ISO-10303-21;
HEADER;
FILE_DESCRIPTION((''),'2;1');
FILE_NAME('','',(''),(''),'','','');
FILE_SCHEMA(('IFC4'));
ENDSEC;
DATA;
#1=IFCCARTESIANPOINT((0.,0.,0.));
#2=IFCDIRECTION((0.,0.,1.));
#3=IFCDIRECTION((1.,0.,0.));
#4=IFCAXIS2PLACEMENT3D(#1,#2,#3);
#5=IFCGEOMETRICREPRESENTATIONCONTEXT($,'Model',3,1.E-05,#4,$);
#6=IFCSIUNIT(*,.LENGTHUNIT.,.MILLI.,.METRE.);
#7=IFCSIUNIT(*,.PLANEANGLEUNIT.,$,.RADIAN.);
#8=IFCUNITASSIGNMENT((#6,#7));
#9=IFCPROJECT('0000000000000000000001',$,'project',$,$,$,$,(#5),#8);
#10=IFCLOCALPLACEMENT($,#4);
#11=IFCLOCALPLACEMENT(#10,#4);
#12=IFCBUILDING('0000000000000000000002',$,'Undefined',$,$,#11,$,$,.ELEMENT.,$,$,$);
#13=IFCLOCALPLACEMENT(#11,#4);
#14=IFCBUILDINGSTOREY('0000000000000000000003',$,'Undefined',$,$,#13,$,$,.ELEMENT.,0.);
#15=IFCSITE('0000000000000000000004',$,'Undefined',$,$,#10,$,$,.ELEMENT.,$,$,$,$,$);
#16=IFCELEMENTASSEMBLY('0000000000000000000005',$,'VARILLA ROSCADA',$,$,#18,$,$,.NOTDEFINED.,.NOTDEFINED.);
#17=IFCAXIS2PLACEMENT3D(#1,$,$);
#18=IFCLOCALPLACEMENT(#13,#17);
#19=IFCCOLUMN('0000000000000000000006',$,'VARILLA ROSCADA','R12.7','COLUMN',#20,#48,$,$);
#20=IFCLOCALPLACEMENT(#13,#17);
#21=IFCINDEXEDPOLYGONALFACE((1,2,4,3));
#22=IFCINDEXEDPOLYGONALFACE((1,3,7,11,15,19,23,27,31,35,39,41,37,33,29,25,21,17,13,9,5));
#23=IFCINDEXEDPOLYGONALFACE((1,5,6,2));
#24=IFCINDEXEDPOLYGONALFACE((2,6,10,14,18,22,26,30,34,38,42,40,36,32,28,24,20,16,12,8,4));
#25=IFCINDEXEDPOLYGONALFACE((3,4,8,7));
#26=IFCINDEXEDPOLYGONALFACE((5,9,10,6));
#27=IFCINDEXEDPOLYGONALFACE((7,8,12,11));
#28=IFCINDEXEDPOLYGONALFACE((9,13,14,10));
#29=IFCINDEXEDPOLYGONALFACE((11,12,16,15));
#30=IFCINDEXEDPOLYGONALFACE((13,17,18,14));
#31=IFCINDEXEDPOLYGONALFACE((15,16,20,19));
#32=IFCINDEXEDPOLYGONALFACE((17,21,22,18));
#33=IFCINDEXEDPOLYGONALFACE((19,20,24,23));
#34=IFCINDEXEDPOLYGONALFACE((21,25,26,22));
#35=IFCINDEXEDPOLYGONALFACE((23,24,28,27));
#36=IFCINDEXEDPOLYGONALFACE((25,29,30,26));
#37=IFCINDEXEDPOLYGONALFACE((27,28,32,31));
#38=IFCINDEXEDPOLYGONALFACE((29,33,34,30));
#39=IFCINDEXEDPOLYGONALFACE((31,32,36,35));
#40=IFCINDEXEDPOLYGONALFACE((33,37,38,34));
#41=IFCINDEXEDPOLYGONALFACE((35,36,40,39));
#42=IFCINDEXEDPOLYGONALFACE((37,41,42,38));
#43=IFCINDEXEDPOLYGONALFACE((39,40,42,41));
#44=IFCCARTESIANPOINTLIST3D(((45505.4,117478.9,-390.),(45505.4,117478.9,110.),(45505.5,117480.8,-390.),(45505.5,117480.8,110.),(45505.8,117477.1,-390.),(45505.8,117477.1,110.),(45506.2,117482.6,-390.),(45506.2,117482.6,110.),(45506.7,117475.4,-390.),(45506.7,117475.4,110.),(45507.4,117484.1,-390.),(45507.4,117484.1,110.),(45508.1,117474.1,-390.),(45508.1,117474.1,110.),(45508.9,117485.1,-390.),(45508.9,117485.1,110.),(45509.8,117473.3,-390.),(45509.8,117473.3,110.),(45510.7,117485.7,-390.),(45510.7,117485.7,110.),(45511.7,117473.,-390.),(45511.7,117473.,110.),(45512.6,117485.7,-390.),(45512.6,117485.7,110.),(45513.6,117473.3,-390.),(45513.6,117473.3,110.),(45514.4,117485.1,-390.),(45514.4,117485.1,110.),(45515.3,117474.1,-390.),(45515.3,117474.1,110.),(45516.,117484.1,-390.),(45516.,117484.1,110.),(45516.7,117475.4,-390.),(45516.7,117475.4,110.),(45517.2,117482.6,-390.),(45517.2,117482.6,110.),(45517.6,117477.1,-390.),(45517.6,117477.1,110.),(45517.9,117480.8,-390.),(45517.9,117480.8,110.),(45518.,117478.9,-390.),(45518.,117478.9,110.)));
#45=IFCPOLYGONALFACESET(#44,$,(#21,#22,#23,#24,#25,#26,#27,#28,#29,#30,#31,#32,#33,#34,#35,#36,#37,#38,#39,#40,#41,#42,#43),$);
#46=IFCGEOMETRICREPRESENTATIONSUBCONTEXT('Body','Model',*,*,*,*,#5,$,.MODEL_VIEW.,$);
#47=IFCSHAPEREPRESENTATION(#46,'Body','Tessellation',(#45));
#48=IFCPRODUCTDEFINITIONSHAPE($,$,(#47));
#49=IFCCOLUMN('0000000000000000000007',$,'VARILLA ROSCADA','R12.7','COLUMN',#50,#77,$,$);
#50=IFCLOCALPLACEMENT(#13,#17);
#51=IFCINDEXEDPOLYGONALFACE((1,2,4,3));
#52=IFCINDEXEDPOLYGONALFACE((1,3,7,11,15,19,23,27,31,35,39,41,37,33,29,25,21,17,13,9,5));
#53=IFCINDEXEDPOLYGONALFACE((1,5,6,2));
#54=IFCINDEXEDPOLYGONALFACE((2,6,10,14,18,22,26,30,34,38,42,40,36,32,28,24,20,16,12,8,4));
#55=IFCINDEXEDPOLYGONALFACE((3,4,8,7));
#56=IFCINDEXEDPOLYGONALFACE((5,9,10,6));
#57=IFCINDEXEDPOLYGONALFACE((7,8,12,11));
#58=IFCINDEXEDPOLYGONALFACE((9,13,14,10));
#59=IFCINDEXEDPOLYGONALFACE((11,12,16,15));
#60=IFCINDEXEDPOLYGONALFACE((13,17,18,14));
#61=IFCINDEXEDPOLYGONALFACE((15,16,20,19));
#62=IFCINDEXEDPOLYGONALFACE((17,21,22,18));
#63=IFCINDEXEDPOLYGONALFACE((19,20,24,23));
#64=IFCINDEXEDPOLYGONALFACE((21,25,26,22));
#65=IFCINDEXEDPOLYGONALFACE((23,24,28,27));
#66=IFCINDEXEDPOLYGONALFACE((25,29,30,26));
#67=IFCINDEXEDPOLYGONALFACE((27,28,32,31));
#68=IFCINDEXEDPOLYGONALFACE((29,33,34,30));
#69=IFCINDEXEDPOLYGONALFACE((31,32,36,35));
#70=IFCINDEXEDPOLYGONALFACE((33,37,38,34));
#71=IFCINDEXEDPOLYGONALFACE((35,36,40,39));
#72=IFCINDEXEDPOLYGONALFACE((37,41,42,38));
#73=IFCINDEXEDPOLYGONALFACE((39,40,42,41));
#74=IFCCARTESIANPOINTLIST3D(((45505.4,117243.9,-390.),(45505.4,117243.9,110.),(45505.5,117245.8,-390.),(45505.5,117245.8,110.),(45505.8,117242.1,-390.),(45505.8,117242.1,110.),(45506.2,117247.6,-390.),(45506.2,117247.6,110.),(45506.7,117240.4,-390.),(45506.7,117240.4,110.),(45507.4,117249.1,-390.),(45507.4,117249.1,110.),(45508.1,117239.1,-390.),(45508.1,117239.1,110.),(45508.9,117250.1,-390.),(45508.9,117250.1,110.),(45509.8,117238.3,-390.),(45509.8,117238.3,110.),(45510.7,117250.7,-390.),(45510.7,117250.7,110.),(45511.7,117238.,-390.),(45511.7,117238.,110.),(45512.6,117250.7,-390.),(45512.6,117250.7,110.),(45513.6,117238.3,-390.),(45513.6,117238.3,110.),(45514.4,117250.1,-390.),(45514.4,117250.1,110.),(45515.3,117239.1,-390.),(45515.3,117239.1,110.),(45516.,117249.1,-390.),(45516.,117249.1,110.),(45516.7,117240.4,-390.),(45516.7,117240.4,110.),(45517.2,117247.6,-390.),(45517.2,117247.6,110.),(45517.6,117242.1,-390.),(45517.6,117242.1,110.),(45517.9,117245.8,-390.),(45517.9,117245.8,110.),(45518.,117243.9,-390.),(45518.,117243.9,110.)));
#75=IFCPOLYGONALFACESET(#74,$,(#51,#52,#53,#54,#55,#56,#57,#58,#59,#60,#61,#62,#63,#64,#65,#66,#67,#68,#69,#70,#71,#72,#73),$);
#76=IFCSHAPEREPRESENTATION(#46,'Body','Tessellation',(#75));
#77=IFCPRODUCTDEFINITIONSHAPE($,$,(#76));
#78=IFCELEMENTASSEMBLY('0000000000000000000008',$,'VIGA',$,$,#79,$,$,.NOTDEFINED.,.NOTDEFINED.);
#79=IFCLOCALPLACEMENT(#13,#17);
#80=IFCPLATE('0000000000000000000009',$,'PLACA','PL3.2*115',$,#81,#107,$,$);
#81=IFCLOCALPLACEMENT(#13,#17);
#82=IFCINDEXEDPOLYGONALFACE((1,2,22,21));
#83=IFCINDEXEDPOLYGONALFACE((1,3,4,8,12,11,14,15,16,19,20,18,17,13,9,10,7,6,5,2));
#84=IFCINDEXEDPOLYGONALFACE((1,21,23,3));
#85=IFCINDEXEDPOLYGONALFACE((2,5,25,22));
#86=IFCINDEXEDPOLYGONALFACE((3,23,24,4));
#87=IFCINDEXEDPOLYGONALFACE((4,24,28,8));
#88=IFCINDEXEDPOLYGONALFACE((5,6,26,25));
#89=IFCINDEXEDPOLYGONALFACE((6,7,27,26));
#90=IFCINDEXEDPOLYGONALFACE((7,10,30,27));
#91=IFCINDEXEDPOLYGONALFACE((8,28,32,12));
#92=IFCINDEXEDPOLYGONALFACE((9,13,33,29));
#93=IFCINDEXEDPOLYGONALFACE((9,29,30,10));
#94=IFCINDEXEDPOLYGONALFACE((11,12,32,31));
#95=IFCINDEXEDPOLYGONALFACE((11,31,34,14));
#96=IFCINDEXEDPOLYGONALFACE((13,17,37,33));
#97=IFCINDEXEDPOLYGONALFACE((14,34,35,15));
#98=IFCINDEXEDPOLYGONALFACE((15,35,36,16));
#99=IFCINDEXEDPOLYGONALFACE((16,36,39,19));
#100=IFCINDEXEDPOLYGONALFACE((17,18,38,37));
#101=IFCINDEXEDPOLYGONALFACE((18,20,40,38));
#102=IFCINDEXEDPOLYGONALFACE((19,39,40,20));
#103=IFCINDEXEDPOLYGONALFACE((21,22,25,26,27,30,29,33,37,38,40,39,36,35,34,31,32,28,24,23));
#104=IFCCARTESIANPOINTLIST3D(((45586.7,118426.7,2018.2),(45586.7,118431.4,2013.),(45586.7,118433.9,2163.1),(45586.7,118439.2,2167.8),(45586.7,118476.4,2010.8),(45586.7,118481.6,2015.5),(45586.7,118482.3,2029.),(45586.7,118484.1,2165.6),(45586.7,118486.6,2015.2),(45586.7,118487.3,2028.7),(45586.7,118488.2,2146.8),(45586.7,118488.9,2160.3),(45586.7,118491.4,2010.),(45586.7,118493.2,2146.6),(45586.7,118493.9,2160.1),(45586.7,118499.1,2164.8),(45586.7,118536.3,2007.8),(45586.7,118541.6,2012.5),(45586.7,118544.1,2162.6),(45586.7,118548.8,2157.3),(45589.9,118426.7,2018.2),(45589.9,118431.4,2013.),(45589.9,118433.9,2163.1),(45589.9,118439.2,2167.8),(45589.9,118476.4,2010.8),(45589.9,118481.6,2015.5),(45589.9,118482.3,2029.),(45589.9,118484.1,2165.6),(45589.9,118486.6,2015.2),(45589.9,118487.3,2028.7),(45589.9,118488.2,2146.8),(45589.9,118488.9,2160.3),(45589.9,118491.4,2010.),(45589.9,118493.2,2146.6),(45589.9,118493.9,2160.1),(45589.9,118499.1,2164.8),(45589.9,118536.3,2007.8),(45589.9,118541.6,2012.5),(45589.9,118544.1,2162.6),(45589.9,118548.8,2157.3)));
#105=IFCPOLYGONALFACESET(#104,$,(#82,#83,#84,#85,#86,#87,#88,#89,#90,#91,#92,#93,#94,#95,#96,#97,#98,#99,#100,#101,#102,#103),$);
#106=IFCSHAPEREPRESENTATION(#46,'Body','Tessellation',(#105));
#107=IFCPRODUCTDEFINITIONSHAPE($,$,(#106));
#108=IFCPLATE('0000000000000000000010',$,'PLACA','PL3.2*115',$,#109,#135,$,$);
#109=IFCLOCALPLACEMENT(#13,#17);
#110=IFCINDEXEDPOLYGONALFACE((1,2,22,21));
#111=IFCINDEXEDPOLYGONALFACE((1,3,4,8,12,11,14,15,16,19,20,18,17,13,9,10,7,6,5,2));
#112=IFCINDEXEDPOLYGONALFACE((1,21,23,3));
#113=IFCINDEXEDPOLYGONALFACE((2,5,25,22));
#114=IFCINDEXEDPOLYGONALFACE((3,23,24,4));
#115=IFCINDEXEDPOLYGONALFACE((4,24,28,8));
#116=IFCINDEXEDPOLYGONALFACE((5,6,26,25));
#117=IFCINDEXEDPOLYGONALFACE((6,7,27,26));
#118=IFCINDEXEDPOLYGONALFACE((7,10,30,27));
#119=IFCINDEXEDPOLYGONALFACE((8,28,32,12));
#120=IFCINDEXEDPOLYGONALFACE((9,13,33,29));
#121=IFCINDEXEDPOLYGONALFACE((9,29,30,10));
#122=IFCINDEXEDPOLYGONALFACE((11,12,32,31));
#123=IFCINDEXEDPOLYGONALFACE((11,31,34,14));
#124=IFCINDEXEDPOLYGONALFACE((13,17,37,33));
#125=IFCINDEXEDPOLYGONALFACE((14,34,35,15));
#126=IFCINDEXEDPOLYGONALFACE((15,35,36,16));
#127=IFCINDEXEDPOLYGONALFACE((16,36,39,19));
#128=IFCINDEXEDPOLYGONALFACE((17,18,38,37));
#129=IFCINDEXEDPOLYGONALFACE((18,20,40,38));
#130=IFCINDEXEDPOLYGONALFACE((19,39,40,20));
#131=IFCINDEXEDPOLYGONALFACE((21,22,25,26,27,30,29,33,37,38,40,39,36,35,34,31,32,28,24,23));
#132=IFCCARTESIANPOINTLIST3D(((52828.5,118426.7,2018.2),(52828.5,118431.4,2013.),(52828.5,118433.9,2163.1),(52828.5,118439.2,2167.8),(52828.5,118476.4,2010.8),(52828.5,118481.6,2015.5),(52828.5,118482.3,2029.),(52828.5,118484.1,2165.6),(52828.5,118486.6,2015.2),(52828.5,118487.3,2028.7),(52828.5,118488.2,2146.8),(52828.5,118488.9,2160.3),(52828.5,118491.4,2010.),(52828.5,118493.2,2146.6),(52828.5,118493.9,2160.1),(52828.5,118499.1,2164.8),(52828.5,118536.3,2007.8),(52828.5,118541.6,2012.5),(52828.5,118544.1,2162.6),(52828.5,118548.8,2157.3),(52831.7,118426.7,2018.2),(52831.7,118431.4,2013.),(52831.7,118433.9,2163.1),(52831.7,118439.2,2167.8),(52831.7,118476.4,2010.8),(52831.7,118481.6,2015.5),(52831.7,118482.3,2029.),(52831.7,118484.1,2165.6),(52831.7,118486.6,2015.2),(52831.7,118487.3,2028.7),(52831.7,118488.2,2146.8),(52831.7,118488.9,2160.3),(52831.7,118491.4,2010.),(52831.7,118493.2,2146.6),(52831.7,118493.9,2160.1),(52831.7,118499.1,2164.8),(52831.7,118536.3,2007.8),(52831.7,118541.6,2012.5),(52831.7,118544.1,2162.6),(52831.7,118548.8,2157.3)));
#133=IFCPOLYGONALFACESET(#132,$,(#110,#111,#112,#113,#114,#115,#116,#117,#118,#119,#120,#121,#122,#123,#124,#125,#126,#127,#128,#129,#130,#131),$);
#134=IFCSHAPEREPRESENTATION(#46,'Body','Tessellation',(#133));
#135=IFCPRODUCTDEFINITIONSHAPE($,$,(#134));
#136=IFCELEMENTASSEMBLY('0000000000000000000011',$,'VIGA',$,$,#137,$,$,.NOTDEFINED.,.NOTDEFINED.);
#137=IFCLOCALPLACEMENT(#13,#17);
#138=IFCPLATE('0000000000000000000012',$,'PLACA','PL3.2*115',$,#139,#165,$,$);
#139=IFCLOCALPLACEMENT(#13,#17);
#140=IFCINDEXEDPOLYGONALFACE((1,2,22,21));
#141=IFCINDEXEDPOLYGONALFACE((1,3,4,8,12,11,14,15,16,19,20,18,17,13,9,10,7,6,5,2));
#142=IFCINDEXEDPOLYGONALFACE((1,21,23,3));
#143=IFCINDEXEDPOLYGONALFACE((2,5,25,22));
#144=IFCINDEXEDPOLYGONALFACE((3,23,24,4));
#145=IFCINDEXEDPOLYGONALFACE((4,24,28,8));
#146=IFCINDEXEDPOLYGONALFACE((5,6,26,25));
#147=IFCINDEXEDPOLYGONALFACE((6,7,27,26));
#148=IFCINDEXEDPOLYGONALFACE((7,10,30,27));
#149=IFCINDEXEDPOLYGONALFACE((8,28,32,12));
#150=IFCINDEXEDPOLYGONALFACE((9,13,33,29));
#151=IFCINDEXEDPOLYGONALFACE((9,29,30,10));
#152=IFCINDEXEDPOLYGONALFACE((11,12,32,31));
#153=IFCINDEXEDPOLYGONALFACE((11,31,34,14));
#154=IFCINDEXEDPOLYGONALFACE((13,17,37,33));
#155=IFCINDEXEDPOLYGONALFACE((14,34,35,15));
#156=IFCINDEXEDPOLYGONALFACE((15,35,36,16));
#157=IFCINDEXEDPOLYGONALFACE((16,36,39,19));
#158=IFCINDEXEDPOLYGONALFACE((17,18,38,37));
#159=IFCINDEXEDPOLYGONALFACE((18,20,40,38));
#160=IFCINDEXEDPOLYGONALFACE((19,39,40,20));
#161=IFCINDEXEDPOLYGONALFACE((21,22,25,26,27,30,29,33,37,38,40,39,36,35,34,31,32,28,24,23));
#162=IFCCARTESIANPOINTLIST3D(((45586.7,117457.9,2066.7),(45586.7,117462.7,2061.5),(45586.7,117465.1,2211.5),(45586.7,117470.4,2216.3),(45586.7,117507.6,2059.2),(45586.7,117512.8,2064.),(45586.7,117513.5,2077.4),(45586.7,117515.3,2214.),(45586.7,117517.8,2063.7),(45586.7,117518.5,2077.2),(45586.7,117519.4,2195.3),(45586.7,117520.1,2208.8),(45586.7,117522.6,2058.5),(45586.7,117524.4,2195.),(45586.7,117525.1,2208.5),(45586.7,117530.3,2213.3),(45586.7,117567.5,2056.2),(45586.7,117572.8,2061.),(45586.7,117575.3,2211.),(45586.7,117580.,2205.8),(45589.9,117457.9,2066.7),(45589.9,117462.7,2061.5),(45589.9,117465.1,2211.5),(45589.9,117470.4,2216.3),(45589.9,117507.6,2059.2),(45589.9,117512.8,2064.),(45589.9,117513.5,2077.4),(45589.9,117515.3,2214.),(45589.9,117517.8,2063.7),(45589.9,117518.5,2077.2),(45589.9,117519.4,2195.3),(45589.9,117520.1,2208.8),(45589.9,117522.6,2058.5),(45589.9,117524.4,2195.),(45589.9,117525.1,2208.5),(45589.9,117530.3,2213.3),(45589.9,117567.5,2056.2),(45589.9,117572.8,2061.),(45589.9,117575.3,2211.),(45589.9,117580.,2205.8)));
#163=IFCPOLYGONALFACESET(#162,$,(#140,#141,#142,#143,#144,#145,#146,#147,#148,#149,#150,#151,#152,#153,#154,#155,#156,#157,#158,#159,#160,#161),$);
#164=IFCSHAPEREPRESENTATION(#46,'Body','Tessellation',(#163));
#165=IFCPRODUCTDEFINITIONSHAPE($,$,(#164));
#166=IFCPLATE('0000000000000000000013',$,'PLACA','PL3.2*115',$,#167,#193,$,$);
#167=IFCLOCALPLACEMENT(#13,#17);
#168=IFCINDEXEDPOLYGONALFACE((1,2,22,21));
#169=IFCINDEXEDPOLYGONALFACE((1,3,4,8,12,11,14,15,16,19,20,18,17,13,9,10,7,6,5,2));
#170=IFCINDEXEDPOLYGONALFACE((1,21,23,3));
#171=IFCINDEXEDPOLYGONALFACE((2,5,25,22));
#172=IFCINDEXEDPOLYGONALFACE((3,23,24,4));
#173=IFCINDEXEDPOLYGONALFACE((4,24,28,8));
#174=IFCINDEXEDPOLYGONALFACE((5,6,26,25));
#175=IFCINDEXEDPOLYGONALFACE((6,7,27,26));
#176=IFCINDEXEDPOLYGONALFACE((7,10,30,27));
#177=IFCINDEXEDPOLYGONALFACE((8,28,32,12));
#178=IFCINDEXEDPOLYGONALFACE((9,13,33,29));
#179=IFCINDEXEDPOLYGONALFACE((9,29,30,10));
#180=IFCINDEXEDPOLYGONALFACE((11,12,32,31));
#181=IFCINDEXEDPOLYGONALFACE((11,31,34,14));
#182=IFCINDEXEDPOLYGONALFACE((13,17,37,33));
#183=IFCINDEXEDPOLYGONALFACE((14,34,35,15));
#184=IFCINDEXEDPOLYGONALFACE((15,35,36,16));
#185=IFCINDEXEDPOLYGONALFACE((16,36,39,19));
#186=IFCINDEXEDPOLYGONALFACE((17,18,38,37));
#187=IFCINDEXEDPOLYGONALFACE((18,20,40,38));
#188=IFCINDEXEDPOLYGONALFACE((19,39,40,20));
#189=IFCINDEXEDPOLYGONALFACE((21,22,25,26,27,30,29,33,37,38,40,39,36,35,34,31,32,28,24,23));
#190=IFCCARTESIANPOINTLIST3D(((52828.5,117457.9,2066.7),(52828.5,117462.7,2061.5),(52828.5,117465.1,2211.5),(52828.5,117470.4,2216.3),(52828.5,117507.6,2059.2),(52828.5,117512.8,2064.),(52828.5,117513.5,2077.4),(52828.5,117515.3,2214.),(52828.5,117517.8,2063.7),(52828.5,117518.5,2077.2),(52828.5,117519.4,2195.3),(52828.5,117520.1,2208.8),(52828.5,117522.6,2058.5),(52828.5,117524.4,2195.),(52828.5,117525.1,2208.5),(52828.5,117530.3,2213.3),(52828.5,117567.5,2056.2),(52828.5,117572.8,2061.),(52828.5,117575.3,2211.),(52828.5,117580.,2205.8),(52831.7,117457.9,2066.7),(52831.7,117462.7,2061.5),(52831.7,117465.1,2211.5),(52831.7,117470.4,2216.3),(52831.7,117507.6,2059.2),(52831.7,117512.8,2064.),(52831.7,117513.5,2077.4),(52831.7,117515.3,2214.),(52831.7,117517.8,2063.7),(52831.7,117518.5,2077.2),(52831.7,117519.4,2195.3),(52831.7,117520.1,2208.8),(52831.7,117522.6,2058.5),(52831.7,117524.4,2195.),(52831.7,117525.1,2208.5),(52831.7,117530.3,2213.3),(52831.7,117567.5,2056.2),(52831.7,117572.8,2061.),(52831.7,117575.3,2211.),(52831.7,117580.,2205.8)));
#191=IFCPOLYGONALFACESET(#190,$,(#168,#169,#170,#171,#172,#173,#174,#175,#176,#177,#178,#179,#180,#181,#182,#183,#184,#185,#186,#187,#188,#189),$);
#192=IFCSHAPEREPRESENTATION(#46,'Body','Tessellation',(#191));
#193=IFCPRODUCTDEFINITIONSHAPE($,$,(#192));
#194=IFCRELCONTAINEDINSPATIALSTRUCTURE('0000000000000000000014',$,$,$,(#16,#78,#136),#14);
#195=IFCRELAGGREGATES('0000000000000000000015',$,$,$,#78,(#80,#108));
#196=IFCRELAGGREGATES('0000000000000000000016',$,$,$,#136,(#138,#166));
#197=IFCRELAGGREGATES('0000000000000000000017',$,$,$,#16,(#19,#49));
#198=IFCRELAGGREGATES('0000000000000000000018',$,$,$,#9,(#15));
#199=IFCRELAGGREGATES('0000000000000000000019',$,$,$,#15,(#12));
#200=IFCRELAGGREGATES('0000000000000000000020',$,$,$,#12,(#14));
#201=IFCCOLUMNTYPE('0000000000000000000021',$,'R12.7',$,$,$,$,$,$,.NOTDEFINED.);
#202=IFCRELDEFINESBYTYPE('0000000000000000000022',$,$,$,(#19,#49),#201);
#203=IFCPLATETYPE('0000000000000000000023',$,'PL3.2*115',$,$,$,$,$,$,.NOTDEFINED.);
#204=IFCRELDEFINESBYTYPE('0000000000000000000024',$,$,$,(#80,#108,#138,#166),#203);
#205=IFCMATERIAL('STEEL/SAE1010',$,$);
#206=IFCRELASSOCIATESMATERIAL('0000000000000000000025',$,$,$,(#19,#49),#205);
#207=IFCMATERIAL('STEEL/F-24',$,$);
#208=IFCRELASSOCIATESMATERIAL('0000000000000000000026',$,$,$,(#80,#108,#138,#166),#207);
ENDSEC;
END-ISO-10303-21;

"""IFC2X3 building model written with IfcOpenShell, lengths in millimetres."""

from ifc_helpers import new_model, si_unit, frame, origin_with_axes, origin_2d_with_axis, place, context, subcontext, project, spatial, polyline, circle, outline, extrude, material, type_object, element, aggregate, save


model = new_model("IFC2X3")

# Units and contexts
model_context = context("Model", 3, precision=1e-05, world=origin_with_axes())
body_context = subcontext(model_context, "Body", "Model", "MODEL_VIEW")
ifc_project = project(units=[si_unit("LENGTHUNIT", "METRE", prefix="MILLI"), si_unit("PLANEANGLEUNIT", "RADIAN")], contexts=[model_context])

# Site, building, storey
site_placement = place(None, origin_with_axes())
site = spatial("IfcSite", under=ifc_project, at=site_placement, Name="Undefined", CompositionType="ELEMENT")
building_placement = place(site_placement, origin_with_axes())
building = spatial("IfcBuilding", under=site, at=building_placement, Name="Undefined", CompositionType="ELEMENT")
storey_placement = place(building_placement, origin_with_axes())
storey = spatial("IfcBuildingStorey", under=building, at=storey_placement, Name="Undefined", CompositionType="ELEMENT", Elevation=0.0)

# Element assembly, columns
assembly_1_placement = place(storey_placement, origin_with_axes())
assembly_1 = element("IfcElementAssembly", 1, at=assembly_1_placement, inside=storey, Name="VARILLA ROSCADA", AssemblyPlace="NOTDEFINED", PredefinedType="NOTDEFINED")
ifc_material_1 = material(Name="STEEL/SAE1010")
column_type = type_object("IfcColumnType", Name="R12.7", PredefinedType="NOTDEFINED")
column_1_placement = place(assembly_1_placement, frame((45511.7, 117479.4, -390.0), z_axis=(0.0, 0.0, 1.0), x_axis=(-1.0, 0.0, 0.0)))
column_1 = element("IfcColumn", 2, at=column_1_placement, type_object=column_type, material=ifc_material_1, Name="VARILLA ROSCADA", Description="R12.7", ObjectType="COLUMN", context=body_context, shape_type="SweptSolid", body=[
    extrude(circle(Radius=6.3, at=origin_2d_with_axis()), frame((0.0, 0.0, 500.0), z_axis=(0.0, 0.0, -1.0), x_axis=(0.0, 1.0, 0.0)), (0.0, 0.0, 1.0), 500.0),
])
column_2_placement = place(assembly_1_placement, frame((45511.7, 117244.4, -390.0), z_axis=(0.0, 0.0, 1.0), x_axis=(-1.0, 0.0, 0.0)))
column_2 = element("IfcColumn", 3, at=column_2_placement, type_object=column_type, material=ifc_material_1, Name="VARILLA ROSCADA", Description="R12.7", ObjectType="COLUMN", context=body_context, shape_type="SweptSolid", body=[
    extrude(circle(Radius=6.3, at=origin_2d_with_axis()), frame((0.0, 0.0, 500.0), z_axis=(0.0, 0.0, -1.0), x_axis=(0.0, 1.0, 0.0)), (0.0, 0.0, 1.0), 500.0),
])

# Element assemblies, plates
assembly_2_placement = place(storey_placement, origin_with_axes())
assembly_2 = element("IfcElementAssembly", 4, at=assembly_2_placement, inside=storey, Name="VIGA", AssemblyPlace="NOTDEFINED", PredefinedType="NOTDEFINED")
ifc_material_2 = material(Name="STEEL/F-24")
plate_type_1 = type_object("IfcPlateType", Name="PL3.2*115", PredefinedType="NOTDEFINED")
plate_1_placement = place(assembly_2_placement, frame((45588.3, 118549.0, 2162.3), z_axis=(1.0, 0.0, 0.0), x_axis=(0.0, -0.998752, 0.04995)))
plate_1 = element("IfcPlate", 5, at=plate_1_placement, type_object=plate_type_1, material=ifc_material_2, Name="PLACA", Description="PL3.2*115", context=body_context, shape_type="SweptSolid", body=[
    extrude(outline(polyline([(0.0, 5.0), (5.0, 0.0), (50.0, 0.0), (55.0, 5.0), (55.0, 18.5), (60.0, 18.5), (60.0, 5.0), (65.0, 0.0), (110.0, 0.0), (115.0, 5.0), (115.0, 150.0), (110.0, 155.0), (65.0, 155.0), (60.0, 150.0), (60.0, 136.5), (55.0, 136.5), (55.0, 150.0), (50.0, 155.0), (5.0, 155.0), (0.0, 150.0), (0.0, 5.0)])), frame((0.0, 0.0, -1.6), z_axis=(0.0, 0.0, 1.0), x_axis=(1.0, 0.0, 0.0)), (0.0, 0.0, 1.0), 3.2),
])
plate_2_placement = place(assembly_2_placement, frame((52830.1, 118549.0, 2162.3), z_axis=(1.0, 0.0, 0.0), x_axis=(0.0, -0.998752, 0.04995)))
plate_2 = element("IfcPlate", 6, at=plate_2_placement, type_object=plate_type_1, material=ifc_material_2, Name="PLACA", Description="PL3.2*115", context=body_context, shape_type="SweptSolid", body=[
    extrude(outline(polyline([(0.0, 5.0), (5.0, 0.0), (50.0, 0.0), (55.0, 5.0), (55.0, 18.5), (60.0, 18.5), (60.0, 5.0), (65.0, 0.0), (110.0, 0.0), (115.0, 5.0), (115.0, 150.0), (110.0, 155.0), (65.0, 155.0), (60.0, 150.0), (60.0, 136.5), (55.0, 136.5), (55.0, 150.0), (50.0, 155.0), (5.0, 155.0), (0.0, 150.0), (0.0, 5.0)])), frame((0.0, 0.0, -1.6), z_axis=(0.0, 0.0, 1.0), x_axis=(1.0, 0.0, 0.0)), (0.0, 0.0, 1.0), 3.2),
])
assembly_3_placement = place(storey_placement, origin_with_axes())
assembly_3 = element("IfcElementAssembly", 7, at=assembly_3_placement, inside=storey, Name="VIGA", AssemblyPlace="NOTDEFINED", PredefinedType="NOTDEFINED")
plate_3_placement = place(assembly_3_placement, frame((45588.3, 117580.3, 2210.8), z_axis=(1.0, 0.0, 0.0), x_axis=(0.0, -0.998752, 0.04995)))
plate_3 = element("IfcPlate", 8, at=plate_3_placement, type_object=plate_type_1, material=ifc_material_2, Name="PLACA", Description="PL3.2*115", context=body_context, shape_type="SweptSolid", body=[
    extrude(outline(polyline([(0.0, 5.0), (5.0, 0.0), (50.0, 0.0), (55.0, 5.0), (55.0, 18.5), (60.0, 18.5), (60.0, 5.0), (65.0, 0.0), (110.0, 0.0), (115.0, 5.0), (115.0, 150.0), (110.0, 155.0), (65.0, 155.0), (60.0, 150.0), (60.0, 136.5), (55.0, 136.5), (55.0, 150.0), (50.0, 155.0), (5.0, 155.0), (0.0, 150.0), (0.0, 5.0)])), frame((0.0, 0.0, -1.6), z_axis=(0.0, 0.0, 1.0), x_axis=(1.0, 0.0, 0.0)), (0.0, 0.0, 1.0), 3.2),
])
plate_4_placement = place(assembly_3_placement, frame((52830.1, 117580.3, 2210.8), z_axis=(1.0, 0.0, 0.0), x_axis=(0.0, -0.998752, 0.04995)))
plate_4 = element("IfcPlate", 9, at=plate_4_placement, type_object=plate_type_1, material=ifc_material_2, Name="PLACA", Description="PL3.2*115", context=body_context, shape_type="SweptSolid", body=[
    extrude(outline(polyline([(0.0, 5.0), (5.0, 0.0), (50.0, 0.0), (55.0, 5.0), (55.0, 18.5), (60.0, 18.5), (60.0, 5.0), (65.0, 0.0), (110.0, 0.0), (115.0, 5.0), (115.0, 150.0), (110.0, 155.0), (65.0, 155.0), (60.0, 150.0), (60.0, 136.5), (55.0, 136.5), (55.0, 150.0), (50.0, 155.0), (5.0, 155.0), (0.0, 150.0), (0.0, 5.0)])), frame((0.0, 0.0, -1.6), z_axis=(0.0, 0.0, 1.0), x_axis=(1.0, 0.0, 0.0)), (0.0, 0.0, 1.0), 3.2),
])

aggregate(assembly_2, [plate_1, plate_2])
aggregate(assembly_3, [plate_3, plate_4])
aggregate(assembly_1, [column_1, column_2])

save(model, "model.ifc")
